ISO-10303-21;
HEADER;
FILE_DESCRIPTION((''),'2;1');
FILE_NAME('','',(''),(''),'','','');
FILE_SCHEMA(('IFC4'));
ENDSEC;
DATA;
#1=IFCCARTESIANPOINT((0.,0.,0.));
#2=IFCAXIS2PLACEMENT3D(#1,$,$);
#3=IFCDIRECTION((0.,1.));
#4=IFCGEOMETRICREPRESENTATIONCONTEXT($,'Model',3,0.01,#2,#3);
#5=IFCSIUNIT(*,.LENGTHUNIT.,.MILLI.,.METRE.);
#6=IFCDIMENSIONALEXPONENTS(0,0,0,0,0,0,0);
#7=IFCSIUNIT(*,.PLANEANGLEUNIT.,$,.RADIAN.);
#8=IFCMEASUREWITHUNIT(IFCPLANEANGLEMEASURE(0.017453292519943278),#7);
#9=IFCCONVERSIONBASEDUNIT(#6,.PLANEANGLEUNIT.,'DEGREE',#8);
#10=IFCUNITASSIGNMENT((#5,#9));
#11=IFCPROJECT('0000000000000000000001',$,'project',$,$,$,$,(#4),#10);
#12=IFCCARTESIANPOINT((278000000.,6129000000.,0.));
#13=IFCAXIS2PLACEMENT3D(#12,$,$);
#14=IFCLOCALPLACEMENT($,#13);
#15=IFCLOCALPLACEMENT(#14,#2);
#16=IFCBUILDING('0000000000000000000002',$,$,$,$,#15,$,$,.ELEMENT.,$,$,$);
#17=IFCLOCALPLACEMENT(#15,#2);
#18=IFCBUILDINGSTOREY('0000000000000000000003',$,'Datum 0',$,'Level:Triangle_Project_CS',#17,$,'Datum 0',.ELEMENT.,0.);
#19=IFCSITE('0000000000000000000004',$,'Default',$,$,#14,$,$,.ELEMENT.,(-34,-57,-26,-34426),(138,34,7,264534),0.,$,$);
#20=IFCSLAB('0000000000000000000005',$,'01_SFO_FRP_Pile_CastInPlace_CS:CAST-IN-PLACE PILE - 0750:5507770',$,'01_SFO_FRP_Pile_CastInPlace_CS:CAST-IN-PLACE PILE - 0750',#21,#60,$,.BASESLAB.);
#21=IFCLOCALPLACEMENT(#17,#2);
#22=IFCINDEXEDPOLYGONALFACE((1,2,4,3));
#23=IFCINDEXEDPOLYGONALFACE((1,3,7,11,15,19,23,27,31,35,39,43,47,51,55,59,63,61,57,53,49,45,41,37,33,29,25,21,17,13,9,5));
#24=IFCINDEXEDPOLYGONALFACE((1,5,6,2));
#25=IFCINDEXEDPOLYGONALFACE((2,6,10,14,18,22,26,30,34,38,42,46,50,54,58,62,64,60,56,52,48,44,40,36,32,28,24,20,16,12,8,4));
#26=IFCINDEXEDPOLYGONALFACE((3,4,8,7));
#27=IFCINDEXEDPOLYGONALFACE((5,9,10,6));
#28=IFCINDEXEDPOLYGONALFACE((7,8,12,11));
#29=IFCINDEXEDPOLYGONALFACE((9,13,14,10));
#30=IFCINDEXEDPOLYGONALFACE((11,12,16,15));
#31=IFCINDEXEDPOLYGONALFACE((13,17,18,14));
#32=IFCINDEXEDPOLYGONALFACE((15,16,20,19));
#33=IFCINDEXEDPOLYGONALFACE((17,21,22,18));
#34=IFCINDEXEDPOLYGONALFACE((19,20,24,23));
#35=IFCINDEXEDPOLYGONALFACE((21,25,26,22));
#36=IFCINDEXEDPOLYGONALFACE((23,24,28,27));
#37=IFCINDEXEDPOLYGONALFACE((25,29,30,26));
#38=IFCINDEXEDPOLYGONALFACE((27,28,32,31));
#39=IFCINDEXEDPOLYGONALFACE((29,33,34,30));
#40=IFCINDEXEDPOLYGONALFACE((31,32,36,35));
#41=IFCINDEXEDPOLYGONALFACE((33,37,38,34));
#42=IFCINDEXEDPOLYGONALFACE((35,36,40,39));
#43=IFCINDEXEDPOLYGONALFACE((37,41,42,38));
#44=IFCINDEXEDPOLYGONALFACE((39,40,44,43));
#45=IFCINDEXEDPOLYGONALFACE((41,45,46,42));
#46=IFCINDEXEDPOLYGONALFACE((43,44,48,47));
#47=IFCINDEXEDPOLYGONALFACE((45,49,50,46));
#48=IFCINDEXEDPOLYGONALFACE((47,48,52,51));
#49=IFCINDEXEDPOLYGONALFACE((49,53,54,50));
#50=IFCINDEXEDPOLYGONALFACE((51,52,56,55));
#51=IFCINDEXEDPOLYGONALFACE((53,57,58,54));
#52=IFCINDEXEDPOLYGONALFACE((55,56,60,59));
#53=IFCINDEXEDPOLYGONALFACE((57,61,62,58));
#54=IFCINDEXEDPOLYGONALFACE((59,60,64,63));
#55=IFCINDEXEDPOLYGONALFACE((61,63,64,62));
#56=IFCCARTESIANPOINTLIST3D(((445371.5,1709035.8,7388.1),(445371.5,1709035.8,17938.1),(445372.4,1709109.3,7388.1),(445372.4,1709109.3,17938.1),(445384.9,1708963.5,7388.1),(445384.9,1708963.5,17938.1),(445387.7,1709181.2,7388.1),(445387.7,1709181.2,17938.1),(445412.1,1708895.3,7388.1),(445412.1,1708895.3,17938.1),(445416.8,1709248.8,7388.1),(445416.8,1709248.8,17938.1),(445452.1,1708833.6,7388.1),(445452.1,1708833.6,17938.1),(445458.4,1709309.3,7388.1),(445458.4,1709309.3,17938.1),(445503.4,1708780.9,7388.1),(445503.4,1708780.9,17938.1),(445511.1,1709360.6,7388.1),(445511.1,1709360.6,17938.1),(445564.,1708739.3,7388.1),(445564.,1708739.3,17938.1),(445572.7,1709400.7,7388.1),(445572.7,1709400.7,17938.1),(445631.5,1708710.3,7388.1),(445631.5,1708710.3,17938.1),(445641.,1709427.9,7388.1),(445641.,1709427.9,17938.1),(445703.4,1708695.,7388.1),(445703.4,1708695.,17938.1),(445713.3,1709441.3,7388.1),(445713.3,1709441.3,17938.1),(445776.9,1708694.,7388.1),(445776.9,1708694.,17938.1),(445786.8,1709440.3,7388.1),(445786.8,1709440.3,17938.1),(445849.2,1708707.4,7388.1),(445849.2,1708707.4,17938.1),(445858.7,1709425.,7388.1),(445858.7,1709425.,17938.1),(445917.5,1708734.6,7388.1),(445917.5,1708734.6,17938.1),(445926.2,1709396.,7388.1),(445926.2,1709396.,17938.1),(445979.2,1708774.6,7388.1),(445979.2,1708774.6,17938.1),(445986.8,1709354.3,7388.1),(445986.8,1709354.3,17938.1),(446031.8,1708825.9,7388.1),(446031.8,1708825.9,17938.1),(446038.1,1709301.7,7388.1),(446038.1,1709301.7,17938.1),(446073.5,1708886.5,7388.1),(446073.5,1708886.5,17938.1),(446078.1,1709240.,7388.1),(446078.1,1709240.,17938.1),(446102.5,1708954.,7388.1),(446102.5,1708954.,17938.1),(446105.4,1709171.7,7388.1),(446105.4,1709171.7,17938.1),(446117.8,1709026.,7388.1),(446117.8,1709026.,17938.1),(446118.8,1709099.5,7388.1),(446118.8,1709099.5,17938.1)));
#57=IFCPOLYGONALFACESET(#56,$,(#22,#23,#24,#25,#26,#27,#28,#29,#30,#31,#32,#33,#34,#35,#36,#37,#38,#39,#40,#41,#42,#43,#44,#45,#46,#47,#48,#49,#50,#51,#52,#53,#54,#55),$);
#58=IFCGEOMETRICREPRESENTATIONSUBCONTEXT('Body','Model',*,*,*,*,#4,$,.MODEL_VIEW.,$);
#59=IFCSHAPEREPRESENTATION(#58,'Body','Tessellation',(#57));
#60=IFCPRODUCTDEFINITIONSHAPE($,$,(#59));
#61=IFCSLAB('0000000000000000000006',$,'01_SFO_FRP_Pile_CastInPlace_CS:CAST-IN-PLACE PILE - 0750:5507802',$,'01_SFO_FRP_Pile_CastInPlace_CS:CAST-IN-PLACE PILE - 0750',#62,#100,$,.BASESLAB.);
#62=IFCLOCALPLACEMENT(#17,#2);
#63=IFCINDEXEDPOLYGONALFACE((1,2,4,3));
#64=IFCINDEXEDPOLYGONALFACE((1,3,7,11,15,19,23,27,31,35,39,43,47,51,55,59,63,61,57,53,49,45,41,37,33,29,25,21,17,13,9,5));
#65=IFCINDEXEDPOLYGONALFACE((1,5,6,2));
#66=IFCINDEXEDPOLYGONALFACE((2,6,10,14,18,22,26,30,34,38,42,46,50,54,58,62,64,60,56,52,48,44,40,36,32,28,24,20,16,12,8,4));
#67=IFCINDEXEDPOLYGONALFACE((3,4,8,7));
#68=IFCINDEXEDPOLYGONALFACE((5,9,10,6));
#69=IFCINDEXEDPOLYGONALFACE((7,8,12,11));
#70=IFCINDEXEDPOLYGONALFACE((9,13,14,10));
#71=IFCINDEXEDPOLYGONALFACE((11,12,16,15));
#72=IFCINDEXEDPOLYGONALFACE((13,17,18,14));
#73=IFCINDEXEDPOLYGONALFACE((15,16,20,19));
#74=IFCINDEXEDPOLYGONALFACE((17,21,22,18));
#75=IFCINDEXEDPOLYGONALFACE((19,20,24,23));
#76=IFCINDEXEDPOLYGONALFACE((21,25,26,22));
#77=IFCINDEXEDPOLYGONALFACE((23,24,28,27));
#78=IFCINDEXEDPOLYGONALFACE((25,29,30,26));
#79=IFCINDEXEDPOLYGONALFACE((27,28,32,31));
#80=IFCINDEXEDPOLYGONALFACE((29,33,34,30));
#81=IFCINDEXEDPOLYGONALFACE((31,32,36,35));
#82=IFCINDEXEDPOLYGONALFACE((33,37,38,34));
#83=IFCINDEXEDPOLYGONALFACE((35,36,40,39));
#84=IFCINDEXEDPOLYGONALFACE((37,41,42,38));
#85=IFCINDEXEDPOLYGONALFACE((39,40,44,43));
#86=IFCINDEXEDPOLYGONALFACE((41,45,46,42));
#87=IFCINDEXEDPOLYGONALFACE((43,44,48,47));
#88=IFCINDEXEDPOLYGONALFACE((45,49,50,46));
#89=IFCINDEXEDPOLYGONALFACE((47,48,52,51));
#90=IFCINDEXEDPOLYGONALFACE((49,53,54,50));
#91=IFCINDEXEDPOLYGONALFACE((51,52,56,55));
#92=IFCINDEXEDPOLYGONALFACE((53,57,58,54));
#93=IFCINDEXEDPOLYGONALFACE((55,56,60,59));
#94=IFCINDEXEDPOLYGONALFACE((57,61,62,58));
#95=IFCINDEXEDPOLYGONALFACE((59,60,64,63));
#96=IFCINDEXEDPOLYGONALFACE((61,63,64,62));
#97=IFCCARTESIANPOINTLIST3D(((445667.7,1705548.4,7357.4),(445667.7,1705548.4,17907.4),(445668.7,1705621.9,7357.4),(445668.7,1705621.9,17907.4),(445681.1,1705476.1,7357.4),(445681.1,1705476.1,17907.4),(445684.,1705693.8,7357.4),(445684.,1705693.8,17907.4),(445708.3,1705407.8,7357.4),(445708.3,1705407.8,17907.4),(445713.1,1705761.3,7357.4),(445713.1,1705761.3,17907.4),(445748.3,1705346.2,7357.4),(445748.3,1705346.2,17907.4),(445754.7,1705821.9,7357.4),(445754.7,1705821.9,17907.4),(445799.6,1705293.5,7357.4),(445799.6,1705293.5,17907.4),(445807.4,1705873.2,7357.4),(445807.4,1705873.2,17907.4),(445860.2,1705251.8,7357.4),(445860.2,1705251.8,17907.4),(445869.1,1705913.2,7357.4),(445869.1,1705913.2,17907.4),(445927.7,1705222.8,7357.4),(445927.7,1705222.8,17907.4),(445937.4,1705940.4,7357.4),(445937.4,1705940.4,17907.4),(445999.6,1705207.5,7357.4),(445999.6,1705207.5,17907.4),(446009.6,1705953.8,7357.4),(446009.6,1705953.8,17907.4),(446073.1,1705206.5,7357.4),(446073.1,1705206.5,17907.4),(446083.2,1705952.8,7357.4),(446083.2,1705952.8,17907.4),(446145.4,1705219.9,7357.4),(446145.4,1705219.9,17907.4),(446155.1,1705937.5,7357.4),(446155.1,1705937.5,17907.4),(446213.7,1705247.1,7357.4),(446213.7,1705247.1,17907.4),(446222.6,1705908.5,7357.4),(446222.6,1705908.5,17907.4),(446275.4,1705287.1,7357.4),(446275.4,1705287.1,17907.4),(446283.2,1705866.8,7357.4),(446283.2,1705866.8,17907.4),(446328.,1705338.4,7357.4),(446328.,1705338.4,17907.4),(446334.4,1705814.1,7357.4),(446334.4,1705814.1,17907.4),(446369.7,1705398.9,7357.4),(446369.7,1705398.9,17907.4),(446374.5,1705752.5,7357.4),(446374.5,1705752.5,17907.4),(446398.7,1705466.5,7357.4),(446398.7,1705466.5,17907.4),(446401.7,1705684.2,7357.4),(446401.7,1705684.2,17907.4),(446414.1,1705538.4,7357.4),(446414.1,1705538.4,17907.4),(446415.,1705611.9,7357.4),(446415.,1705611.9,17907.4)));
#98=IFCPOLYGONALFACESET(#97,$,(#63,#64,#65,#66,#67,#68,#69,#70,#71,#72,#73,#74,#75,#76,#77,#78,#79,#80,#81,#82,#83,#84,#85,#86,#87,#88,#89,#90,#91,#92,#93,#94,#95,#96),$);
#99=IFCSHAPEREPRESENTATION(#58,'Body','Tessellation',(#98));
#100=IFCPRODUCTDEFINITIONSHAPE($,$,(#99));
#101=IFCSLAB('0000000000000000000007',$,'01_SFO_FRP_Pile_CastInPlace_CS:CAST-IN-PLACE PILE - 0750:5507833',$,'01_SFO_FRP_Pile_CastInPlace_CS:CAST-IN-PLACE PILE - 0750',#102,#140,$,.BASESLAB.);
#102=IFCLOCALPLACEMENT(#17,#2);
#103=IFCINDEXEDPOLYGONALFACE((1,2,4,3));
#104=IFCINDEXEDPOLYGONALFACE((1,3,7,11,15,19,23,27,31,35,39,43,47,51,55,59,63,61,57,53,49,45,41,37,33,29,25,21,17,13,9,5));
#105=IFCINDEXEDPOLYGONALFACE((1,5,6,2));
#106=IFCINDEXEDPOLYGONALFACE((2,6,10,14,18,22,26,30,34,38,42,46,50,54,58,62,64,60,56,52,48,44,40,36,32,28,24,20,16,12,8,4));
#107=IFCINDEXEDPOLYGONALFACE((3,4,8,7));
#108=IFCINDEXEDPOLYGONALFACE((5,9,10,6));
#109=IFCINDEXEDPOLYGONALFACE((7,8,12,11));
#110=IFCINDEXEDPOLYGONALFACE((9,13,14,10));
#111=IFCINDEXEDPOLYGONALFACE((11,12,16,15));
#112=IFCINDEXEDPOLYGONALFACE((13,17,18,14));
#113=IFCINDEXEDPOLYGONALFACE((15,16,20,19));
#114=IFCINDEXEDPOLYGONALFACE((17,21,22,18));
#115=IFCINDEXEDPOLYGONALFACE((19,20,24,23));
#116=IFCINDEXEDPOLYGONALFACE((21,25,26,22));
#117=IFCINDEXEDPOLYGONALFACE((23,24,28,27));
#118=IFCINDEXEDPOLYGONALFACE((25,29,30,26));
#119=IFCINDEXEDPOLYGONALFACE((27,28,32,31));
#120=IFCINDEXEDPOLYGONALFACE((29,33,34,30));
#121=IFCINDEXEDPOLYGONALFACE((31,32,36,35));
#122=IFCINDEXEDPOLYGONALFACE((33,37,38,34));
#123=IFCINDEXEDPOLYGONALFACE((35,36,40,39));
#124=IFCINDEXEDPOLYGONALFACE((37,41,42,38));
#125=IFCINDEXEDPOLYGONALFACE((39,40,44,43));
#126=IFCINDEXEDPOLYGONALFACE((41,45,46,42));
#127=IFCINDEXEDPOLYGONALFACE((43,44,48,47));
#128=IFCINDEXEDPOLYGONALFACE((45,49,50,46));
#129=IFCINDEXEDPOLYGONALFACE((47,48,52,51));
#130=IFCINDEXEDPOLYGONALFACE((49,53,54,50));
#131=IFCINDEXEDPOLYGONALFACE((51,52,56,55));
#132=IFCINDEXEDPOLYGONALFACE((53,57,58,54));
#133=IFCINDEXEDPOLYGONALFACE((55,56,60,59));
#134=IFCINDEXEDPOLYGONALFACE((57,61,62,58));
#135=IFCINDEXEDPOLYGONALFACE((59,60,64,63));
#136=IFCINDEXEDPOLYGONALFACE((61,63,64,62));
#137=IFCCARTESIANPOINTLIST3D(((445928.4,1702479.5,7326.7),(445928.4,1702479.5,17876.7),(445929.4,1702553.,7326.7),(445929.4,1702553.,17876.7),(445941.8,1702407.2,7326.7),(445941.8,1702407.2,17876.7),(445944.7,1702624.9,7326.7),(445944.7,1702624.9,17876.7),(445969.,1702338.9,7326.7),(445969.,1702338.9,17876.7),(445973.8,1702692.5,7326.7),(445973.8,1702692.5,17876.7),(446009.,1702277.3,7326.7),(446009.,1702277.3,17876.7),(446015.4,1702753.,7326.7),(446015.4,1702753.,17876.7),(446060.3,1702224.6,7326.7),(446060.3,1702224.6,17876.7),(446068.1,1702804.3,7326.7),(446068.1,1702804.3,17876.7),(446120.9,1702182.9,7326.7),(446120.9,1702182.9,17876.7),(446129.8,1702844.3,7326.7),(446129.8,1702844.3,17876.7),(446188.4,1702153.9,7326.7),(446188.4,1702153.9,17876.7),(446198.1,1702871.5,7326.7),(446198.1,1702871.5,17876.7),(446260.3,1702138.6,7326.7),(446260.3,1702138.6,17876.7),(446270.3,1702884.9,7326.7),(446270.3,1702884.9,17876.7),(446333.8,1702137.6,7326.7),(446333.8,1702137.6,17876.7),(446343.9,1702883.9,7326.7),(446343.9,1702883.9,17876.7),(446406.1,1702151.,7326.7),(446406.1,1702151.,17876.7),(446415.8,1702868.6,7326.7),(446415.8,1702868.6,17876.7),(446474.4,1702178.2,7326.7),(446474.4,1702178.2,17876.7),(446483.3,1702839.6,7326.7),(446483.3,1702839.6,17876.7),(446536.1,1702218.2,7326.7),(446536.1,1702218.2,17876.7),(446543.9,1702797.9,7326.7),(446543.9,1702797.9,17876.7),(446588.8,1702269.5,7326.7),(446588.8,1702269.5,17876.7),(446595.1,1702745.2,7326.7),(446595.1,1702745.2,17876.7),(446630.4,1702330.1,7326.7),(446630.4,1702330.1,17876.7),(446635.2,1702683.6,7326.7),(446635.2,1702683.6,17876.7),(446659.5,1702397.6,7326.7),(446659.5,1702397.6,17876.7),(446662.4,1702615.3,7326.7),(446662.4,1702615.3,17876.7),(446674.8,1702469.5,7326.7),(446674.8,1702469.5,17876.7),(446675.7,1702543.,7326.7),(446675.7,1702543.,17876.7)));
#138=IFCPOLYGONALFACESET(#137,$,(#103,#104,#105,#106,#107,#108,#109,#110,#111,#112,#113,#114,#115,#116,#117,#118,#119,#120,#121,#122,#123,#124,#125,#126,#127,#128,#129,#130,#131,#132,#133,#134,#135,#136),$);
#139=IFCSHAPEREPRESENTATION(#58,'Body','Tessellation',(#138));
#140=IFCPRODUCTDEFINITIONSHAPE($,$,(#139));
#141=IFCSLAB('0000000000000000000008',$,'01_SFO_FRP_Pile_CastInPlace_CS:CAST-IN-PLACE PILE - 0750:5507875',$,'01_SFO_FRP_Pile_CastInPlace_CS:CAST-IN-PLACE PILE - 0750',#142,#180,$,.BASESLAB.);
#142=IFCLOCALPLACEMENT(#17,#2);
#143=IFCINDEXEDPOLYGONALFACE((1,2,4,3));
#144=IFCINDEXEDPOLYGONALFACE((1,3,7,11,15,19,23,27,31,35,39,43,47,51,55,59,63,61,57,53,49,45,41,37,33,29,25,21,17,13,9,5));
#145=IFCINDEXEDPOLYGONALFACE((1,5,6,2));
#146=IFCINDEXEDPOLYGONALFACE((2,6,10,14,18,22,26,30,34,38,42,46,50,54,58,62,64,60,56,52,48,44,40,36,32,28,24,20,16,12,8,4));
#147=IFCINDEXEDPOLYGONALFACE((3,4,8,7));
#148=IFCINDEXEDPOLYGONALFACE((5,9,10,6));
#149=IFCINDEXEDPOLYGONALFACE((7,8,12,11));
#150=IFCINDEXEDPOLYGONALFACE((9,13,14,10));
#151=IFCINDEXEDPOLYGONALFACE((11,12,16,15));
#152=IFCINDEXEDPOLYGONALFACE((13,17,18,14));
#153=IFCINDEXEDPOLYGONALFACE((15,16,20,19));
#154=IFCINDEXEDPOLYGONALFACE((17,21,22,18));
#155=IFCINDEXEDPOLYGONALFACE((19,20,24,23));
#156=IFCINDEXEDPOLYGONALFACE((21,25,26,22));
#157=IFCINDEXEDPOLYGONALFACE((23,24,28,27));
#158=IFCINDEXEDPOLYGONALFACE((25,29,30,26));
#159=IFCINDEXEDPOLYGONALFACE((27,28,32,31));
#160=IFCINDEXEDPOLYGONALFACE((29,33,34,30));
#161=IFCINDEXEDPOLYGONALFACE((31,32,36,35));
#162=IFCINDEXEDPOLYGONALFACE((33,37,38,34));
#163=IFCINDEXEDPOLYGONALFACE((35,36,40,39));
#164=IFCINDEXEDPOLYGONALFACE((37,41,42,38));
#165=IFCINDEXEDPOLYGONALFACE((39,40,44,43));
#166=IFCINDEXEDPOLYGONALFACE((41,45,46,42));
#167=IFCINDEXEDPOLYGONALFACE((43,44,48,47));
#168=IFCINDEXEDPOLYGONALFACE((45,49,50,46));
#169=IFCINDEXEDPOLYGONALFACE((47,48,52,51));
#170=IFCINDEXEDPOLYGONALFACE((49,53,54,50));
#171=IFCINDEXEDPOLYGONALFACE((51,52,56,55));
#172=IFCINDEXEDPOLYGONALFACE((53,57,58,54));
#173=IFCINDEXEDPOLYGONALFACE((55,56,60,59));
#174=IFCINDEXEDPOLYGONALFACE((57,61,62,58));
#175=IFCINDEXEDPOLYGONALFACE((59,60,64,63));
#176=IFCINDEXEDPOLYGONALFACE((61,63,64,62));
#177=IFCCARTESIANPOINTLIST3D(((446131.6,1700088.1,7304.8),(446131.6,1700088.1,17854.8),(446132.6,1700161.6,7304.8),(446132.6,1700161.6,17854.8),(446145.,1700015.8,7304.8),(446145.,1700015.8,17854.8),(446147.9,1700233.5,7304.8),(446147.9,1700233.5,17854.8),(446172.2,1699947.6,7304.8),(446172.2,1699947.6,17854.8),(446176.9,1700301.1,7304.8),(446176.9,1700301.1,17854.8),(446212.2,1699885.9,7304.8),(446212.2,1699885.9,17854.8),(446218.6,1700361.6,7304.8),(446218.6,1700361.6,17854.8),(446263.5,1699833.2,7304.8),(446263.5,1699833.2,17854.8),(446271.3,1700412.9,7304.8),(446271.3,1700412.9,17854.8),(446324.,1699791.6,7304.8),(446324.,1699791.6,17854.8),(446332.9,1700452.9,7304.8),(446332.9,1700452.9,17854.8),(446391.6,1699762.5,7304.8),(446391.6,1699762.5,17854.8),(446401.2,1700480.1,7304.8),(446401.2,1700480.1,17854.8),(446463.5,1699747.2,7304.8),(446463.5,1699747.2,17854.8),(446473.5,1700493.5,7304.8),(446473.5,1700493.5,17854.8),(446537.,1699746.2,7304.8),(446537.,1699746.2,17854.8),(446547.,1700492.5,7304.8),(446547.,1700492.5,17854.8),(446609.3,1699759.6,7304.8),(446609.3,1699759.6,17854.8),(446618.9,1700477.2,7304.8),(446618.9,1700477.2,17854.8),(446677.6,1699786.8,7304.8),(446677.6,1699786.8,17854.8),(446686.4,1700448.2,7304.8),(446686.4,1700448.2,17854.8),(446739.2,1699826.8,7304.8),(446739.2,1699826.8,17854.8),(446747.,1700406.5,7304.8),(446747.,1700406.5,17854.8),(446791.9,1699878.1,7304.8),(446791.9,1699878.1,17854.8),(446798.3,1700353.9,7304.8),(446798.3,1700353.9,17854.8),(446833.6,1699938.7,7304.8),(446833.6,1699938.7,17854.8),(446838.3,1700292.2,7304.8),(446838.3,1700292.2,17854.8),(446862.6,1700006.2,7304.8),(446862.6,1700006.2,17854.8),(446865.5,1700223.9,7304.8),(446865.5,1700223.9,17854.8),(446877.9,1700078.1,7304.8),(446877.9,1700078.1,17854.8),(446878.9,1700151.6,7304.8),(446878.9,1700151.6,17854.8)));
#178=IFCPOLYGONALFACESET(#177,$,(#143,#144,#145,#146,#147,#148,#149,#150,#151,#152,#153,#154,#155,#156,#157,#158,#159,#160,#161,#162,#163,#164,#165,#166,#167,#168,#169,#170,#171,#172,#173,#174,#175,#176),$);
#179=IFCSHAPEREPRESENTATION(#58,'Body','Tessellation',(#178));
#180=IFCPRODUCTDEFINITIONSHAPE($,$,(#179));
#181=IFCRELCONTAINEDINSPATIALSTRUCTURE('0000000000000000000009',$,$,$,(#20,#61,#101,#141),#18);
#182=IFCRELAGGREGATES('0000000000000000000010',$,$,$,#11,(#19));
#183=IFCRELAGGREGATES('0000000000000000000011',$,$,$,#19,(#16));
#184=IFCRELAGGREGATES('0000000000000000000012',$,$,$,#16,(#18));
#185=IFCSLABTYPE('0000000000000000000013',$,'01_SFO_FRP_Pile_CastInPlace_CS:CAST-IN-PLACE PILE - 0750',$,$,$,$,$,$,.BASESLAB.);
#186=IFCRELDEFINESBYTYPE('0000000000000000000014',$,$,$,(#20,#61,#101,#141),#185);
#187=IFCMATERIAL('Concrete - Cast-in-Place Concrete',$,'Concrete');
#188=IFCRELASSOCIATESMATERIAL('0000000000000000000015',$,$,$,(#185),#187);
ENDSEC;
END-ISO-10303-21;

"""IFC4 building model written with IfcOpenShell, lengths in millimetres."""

from ifc_helpers import new_model, entity, si_unit, converted_unit, direction, frame, origin, place, context, subcontext, project, spatial, arc, indexed_curve, outline, extrude, material, type_object, element, save


model = new_model("IFC4")

# Units and contexts
model_context = context("Model", 3, precision=0.01, world=origin(), true_north=direction((0.0, 1.0)))
body_context = subcontext(model_context, "Body", "Model", "MODEL_VIEW")
ifc_project = project(units=[si_unit("LENGTHUNIT", "METRE", prefix="MILLI"), converted_unit("PLANEANGLEUNIT", "DEGREE", entity("IfcPlaneAngleMeasure", 0.017453292519943278), si_unit("PLANEANGLEUNIT", "RADIAN"), dimensions=[0, 0, 0, 0, 0, 0, 0])], contexts=[model_context])

# Site, building, storey
site_placement = place(None, frame((278000000.0, 6129000000.0, 0.0)))
site = spatial("IfcSite", under=ifc_project, at=site_placement, Name="Default", CompositionType="ELEMENT", RefLatitude=(-34, -57, -26, -34426), RefLongitude=(138, 34, 7, 264534), RefElevation=0.0)
building_placement = place(site_placement, origin())
building = spatial("IfcBuilding", under=site, at=building_placement, CompositionType="ELEMENT")
storey_placement = place(building_placement, frame((0.0, 0.0, 0.0)))
storey = spatial("IfcBuildingStorey", under=building, at=storey_placement, Name="Datum 0", ObjectType="Level:Triangle_Project_CS", LongName="Datum 0", CompositionType="ELEMENT", Elevation=0.0)

# Shared definitions
ifc_material_1 = material(Name="Concrete - Cast-in-Place Concrete", Category="Concrete")

# Slabs
slab_type_1 = type_object("IfcSlabType", Name="01_SFO_FRP_Pile_CastInPlace_CS:CAST-IN-PLACE PILE - 0750", PredefinedType="BASESLAB", material=ifc_material_1)
slab_1_placement = place(storey_placement, origin())
element("IfcSlab", 1, at=slab_1_placement, inside=storey, type_object=slab_type_1, Name="01_SFO_FRP_Pile_CastInPlace_CS:CAST-IN-PLACE PILE - 0750:5507770", ObjectType="01_SFO_FRP_Pile_CastInPlace_CS:CAST-IN-PLACE PILE - 0750", PredefinedType="BASESLAB", context=body_context, shape_type="SweptSolid", body=[
    extrude(outline(indexed_curve([(-375.0, 0.0), (0.0, -375.0), (375.0, 0.0), (0.0, 375.0)], segments=[arc(1, 2, 3), arc(3, 4, 1)], self_intersect=False)), frame((445745.1, 1709067.6, 7388.1), z_axis=(0.0, 0.0, 1.0), x_axis=(0.996393, 0.084856, 0.0)), (0.0, 0.0, 1.0), 10550.0),
])
slab_2_placement = place(storey_placement, origin())
element("IfcSlab", 2, at=slab_2_placement, inside=storey, type_object=slab_type_1, Name="01_SFO_FRP_Pile_CastInPlace_CS:CAST-IN-PLACE PILE - 0750:5507802", ObjectType="01_SFO_FRP_Pile_CastInPlace_CS:CAST-IN-PLACE PILE - 0750", PredefinedType="BASESLAB", context=body_context, shape_type="SweptSolid", body=[
    extrude(outline(indexed_curve([(-375.0, 0.0), (0.0, -375.0), (375.0, 0.0), (0.0, 375.0)], segments=[arc(1, 2, 3), arc(3, 4, 1)], self_intersect=False)), frame((446041.4, 1705580.1, 7357.4), z_axis=(0.0, 0.0, 1.0), x_axis=(0.996411, 0.084646, 0.0)), (0.0, 0.0, 1.0), 10550.0),
])
slab_3_placement = place(storey_placement, origin())
element("IfcSlab", 3, at=slab_3_placement, inside=storey, type_object=slab_type_1, Name="01_SFO_FRP_Pile_CastInPlace_CS:CAST-IN-PLACE PILE - 0750:5507833", ObjectType="01_SFO_FRP_Pile_CastInPlace_CS:CAST-IN-PLACE PILE - 0750", PredefinedType="BASESLAB", context=body_context, shape_type="SweptSolid", body=[
    extrude(outline(indexed_curve([(-375.0, 0.0), (0.0, -375.0), (375.0, 0.0), (0.0, 375.0)], segments=[arc(1, 2, 3), arc(3, 4, 1)], self_intersect=False)), frame((446302.1, 1702511.3, 7326.7), z_axis=(0.0, 0.0, 1.0), x_axis=(0.996411, 0.084646, 0.0)), (0.0, 0.0, 1.0), 10550.0),
])
slab_4_placement = place(storey_placement, origin())
element("IfcSlab", 4, at=slab_4_placement, inside=storey, type_object=slab_type_1, Name="01_SFO_FRP_Pile_CastInPlace_CS:CAST-IN-PLACE PILE - 0750:5507875", ObjectType="01_SFO_FRP_Pile_CastInPlace_CS:CAST-IN-PLACE PILE - 0750", PredefinedType="BASESLAB", context=body_context, shape_type="SweptSolid", body=[
    extrude(outline(indexed_curve([(-375.0, 0.0), (0.0, -375.0), (375.0, 0.0), (0.0, 375.0)], segments=[arc(1, 2, 3), arc(3, 4, 1)], self_intersect=False)), frame((446505.2, 1700119.9, 7304.8), z_axis=(0.0, 0.0, 1.0), x_axis=(-0.996411, -0.084646, 0.0)), (0.0, 0.0, 1.0), 10550.0),
])

save(model, "model.ifc")
